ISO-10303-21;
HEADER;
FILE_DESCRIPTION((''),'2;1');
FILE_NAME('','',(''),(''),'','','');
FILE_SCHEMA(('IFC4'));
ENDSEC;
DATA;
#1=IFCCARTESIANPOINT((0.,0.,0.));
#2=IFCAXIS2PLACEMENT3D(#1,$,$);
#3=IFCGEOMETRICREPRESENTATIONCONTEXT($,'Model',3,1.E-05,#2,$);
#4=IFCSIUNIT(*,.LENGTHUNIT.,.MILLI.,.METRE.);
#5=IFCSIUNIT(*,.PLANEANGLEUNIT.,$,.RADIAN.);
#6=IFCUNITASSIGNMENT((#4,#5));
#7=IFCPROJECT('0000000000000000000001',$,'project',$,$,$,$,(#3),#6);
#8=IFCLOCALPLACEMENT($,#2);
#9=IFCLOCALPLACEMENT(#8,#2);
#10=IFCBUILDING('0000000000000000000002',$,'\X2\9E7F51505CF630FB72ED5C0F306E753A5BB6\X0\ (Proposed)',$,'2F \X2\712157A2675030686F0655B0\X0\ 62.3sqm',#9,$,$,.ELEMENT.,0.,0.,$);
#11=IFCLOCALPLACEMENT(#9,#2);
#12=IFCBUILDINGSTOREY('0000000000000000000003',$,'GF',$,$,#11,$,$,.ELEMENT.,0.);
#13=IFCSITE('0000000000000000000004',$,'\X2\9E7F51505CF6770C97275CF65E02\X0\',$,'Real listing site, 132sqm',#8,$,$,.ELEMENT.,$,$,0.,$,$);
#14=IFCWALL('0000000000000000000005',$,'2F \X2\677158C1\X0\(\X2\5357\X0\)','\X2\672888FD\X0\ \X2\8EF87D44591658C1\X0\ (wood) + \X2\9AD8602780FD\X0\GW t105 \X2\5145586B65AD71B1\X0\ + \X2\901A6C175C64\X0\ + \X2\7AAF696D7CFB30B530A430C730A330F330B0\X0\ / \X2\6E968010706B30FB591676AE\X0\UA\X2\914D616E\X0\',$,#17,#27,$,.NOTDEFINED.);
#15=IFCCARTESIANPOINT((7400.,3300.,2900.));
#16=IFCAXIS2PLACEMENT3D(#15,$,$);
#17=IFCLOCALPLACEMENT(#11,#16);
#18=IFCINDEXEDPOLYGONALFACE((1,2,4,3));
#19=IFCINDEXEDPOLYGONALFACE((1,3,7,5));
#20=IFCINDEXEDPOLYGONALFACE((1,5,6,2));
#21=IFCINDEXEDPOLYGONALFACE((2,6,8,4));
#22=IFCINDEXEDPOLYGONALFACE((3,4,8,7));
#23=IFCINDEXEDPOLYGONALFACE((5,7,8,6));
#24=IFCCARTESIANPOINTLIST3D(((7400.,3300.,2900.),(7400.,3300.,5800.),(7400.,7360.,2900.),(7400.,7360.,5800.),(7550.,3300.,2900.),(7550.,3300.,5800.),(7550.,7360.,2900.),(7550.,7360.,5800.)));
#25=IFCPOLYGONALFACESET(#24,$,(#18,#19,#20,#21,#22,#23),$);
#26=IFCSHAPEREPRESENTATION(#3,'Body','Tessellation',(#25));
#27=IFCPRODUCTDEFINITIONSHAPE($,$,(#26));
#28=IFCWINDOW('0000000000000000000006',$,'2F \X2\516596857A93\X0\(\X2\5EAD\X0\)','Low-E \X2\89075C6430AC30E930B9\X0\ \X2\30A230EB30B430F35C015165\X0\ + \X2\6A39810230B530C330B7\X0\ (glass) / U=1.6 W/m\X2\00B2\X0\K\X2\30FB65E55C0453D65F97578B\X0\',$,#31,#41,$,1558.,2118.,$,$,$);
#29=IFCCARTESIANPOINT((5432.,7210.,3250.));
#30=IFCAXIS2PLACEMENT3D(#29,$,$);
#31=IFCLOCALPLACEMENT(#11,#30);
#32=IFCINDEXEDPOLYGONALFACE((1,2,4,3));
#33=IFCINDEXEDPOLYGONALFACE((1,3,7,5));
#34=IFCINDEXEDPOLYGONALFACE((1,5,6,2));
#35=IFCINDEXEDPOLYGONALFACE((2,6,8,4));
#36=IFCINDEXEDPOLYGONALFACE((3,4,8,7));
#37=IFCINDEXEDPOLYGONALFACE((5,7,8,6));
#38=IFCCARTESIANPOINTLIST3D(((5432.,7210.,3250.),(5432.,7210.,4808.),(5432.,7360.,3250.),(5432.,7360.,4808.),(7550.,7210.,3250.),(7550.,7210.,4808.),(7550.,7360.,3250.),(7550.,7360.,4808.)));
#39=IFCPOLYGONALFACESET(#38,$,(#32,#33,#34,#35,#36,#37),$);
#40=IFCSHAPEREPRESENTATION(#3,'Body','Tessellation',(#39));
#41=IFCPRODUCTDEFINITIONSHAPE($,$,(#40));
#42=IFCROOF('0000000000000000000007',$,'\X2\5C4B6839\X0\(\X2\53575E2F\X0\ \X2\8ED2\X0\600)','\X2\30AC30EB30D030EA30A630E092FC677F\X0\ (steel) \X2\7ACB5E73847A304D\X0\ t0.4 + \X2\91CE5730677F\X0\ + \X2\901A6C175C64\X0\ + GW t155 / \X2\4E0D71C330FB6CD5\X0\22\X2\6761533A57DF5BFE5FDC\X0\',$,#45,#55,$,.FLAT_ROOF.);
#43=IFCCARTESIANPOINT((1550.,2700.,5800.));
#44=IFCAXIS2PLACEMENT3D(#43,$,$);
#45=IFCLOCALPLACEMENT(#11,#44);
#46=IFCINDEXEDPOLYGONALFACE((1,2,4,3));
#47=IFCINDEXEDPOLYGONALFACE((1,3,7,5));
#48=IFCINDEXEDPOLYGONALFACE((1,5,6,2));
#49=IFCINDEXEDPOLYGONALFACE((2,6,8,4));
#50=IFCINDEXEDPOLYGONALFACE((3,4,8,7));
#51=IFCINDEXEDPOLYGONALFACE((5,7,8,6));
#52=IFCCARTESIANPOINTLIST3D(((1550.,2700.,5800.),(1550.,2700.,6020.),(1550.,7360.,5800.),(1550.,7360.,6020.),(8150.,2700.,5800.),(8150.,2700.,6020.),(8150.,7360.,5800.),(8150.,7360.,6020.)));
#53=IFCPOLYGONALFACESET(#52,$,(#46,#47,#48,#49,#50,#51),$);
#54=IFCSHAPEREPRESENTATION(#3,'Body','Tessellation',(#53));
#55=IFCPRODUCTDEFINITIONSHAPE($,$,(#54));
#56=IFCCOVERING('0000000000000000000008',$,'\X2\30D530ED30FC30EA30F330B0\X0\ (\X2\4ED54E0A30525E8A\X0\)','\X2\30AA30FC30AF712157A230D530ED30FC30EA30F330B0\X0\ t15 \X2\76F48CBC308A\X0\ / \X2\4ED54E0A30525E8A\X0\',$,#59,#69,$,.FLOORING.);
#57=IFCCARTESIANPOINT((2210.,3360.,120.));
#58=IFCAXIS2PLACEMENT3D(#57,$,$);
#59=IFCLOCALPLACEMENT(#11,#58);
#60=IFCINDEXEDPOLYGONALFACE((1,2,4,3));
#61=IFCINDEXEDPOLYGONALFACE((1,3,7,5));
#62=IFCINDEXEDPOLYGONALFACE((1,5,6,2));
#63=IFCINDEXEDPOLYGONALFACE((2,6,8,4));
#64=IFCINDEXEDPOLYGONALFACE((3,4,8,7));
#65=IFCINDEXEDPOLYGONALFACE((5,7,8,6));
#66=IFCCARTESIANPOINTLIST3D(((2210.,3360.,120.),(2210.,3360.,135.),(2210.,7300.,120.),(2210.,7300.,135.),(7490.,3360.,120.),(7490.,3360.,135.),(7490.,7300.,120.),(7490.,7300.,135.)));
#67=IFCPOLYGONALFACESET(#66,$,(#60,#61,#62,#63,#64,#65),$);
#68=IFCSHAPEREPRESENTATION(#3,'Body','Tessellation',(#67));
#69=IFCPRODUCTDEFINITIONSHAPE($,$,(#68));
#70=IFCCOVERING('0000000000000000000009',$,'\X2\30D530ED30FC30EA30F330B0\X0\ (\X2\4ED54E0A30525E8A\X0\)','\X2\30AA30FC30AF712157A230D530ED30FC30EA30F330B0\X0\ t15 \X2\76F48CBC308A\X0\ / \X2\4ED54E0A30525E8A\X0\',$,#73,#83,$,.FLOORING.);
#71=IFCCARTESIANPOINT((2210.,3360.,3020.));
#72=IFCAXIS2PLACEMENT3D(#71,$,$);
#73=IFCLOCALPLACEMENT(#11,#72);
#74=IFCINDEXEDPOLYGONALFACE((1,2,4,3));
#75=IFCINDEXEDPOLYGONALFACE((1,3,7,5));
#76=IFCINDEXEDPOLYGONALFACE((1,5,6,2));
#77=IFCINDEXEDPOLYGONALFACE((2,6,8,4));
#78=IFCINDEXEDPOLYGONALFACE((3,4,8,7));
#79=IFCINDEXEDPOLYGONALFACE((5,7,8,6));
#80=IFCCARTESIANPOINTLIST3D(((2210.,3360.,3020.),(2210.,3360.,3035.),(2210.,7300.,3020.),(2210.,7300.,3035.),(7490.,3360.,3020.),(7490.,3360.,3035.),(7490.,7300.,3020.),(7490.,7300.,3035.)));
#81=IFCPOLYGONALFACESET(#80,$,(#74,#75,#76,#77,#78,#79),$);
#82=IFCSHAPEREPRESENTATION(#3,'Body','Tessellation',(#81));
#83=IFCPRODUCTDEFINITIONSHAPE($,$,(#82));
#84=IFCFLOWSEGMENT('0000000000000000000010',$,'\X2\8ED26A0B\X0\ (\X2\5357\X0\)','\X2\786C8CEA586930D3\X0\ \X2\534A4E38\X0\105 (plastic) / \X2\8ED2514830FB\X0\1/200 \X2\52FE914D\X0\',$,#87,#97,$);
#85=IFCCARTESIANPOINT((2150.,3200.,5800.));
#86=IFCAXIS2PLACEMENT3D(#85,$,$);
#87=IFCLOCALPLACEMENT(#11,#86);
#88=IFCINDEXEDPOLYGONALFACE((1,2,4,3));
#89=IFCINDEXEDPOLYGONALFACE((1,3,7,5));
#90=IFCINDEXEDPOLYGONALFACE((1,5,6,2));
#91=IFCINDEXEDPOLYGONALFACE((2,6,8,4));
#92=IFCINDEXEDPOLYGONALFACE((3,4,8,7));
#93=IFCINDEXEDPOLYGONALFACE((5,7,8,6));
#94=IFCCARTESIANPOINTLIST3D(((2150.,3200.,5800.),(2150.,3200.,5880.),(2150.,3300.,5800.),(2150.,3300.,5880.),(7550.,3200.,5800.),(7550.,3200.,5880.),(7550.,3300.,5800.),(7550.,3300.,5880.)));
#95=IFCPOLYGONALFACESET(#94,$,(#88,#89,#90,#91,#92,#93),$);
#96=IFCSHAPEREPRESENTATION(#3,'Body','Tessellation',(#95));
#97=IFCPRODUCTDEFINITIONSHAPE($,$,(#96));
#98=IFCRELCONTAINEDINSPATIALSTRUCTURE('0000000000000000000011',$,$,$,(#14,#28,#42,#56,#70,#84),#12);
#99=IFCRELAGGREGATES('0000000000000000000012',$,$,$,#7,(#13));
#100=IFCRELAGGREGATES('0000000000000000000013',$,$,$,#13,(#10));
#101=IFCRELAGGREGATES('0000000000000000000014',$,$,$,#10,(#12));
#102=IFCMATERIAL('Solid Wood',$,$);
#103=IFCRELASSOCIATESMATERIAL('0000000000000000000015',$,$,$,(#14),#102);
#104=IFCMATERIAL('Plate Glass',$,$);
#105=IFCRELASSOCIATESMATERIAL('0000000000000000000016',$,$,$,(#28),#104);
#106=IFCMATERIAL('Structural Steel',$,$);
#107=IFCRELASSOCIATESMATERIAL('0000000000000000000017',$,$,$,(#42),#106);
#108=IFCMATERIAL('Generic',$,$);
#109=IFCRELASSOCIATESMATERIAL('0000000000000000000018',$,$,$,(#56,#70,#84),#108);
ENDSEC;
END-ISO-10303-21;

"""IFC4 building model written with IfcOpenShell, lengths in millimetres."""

from ifc_helpers import new_model, si_unit, frame, frame_2d, origin, place, context, project, spatial, rectangle, extrude, material, element, fill, save


model = new_model("IFC4")

# Units and contexts
model_context = context("Model", 3, precision=1e-05, world=origin())
ifc_project = project(units=[si_unit("LENGTHUNIT", "METRE", prefix="MILLI"), si_unit("PLANEANGLEUNIT", "RADIAN")], contexts=[model_context])

# Site, building, storey
site_placement = place(None, origin())
site = spatial("IfcSite", under=ifc_project, at=site_placement, Name="鹿児島県霧島市", ObjectType="Real listing site, 132sqm", CompositionType="ELEMENT", RefElevation=0.0)
building_placement = place(site_placement, origin())
building = spatial("IfcBuilding", under=site, at=building_placement, Name="鹿児島・狭小の町家 (Proposed)", ObjectType="2F 無垢材と漆喰 62.3sqm", CompositionType="ELEMENT", ElevationOfRefHeight=0.0, ElevationOfTerrain=0.0)
storey_placement = place(building_placement, origin())
storey = spatial("IfcBuildingStorey", under=building, at=storey_placement, Name="GF", CompositionType="ELEMENT", Elevation=0.0)

# Shared definitions
ifc_material_1 = material(Name="Solid Wood")

# Wall, opening, window
ifc_material_2 = material(Name="Plate Glass")
wall_1_placement = place(storey_placement, frame((7400.0, 3300.0, 2900.0)))
wall_1 = element("IfcWall", 1, at=wall_1_placement, inside=storey, material=ifc_material_1, Name="2F 東壁(南)", Description="木製 軸組外壁 (wood) + 高性能GW t105 充填断熱 + 通気層 + 窯業系サイディング / 準耐火・外皮UA配慮", PredefinedType="NOTDEFINED", context=model_context, shape_type="SweptSolid", body=[
    extrude(rectangle(XDim=150.0, YDim=4060.0, at=frame_2d((75.0, 2030.0))), frame((7400.0, 3300.0, 2900.0)), (0.0, 0.0, 1.0), 2900.0),
])
opening_1_placement = place(storey_placement, frame((5432.0, 7210.0, 3250.0)))
opening_1 = element("IfcOpeningElement", 2, at=opening_1_placement, cuts=wall_1, PredefinedType="NOTDEFINED", context=model_context, shape_type="SweptSolid", body=[
    extrude(rectangle(XDim=2118.0, YDim=150.0, at=frame_2d((1059.0, 75.0))), frame((5432.0, 7210.0, 3250.0)), (0.0, 0.0, 1.0), 1558.0),
])
window_1_placement = place(storey_placement, frame((5432.0, 7210.0, 3250.0)))
window_1 = element("IfcWindow", 3, at=window_1_placement, inside=storey, material=ifc_material_2, Name="2F 入隅窓(庭)", Description="Low-E 複層ガラス アルゴン封入 + 樹脂サッシ (glass) / U=1.6 W/m²K・日射取得型", OverallHeight=1558.0, OverallWidth=2118.0, context=model_context, shape_type="SweptSolid", body=[
    extrude(rectangle(XDim=2118.0, YDim=150.0, at=frame_2d((1059.0, 75.0))), frame((5432.0, 7210.0, 3250.0)), (0.0, 0.0, 1.0), 1558.0),
])
fill(opening_1, window_1)

# Roof
ifc_material_3 = material(Name="Structural Steel")
for number, where, name in (
    (4, (1550.0, 2700.0, 5800.0), "屋根(南帯 軒600)"),
):
    element("IfcRoof", number, at=place(storey_placement, frame(where)), inside=storey, material=ifc_material_3, Name=name, Description="ガルバリウム鋼板 (steel) 立平葺き t0.4 + 野地板 + 通気層 + GW t155 / 不燃・法22条区域対応", PredefinedType="FLAT_ROOF", context=model_context, shape_type="SweptSolid", body=[
        extrude(rectangle(XDim=6600.0, YDim=4660.0, at=frame_2d((3300.0, 2330.0))), frame((1550.0, 2700.0, 5800.0)), (0.0, 0.0, 1.0), 220.0),
    ])

# Coverings
ifc_material_4 = material(Name="Generic")
covering_1_placement = place(storey_placement, frame((2210.0, 3360.0, 120.0)))
element("IfcCovering", 5, at=covering_1_placement, inside=storey, material=ifc_material_4, Name="フローリング (仕上げ床)", Description="オーク無垢フローリング t15 直貼り / 仕上げ床", PredefinedType="FLOORING", context=model_context, shape_type="SweptSolid", body=[
    extrude(rectangle(XDim=5280.0, YDim=3940.0, at=frame_2d((2640.0, 1970.0))), frame((2210.0, 3360.0, 120.0)), (0.0, 0.0, 1.0), 15.0),
])
covering_2_placement = place(storey_placement, frame((2210.0, 3360.0, 3020.0)))
element("IfcCovering", 6, at=covering_2_placement, inside=storey, material=ifc_material_4, Name="フローリング (仕上げ床)", Description="オーク無垢フローリング t15 直貼り / 仕上げ床", PredefinedType="FLOORING", context=model_context, shape_type="SweptSolid", body=[
    extrude(rectangle(XDim=5280.0, YDim=3940.0, at=frame_2d((2640.0, 1970.0))), frame((2210.0, 3360.0, 3020.0)), (0.0, 0.0, 1.0), 15.0),
])

# Flow segment
flow_segment_placement = place(storey_placement, frame((2150.0, 3200.0, 5800.0)))
element("IfcFlowSegment", 7, at=flow_segment_placement, inside=storey, material=ifc_material_4, Name="軒樋 (南)", Description="硬質塩ビ 半丸105 (plastic) / 軒先・1/200 勾配", context=model_context, shape_type="SweptSolid", body=[
    extrude(rectangle(XDim=5400.0, YDim=100.0, at=frame_2d((2700.0, 50.0))), frame((2150.0, 3200.0, 5800.0)), (0.0, 0.0, 1.0), 80.0),
])

save(model, "model.ifc")
